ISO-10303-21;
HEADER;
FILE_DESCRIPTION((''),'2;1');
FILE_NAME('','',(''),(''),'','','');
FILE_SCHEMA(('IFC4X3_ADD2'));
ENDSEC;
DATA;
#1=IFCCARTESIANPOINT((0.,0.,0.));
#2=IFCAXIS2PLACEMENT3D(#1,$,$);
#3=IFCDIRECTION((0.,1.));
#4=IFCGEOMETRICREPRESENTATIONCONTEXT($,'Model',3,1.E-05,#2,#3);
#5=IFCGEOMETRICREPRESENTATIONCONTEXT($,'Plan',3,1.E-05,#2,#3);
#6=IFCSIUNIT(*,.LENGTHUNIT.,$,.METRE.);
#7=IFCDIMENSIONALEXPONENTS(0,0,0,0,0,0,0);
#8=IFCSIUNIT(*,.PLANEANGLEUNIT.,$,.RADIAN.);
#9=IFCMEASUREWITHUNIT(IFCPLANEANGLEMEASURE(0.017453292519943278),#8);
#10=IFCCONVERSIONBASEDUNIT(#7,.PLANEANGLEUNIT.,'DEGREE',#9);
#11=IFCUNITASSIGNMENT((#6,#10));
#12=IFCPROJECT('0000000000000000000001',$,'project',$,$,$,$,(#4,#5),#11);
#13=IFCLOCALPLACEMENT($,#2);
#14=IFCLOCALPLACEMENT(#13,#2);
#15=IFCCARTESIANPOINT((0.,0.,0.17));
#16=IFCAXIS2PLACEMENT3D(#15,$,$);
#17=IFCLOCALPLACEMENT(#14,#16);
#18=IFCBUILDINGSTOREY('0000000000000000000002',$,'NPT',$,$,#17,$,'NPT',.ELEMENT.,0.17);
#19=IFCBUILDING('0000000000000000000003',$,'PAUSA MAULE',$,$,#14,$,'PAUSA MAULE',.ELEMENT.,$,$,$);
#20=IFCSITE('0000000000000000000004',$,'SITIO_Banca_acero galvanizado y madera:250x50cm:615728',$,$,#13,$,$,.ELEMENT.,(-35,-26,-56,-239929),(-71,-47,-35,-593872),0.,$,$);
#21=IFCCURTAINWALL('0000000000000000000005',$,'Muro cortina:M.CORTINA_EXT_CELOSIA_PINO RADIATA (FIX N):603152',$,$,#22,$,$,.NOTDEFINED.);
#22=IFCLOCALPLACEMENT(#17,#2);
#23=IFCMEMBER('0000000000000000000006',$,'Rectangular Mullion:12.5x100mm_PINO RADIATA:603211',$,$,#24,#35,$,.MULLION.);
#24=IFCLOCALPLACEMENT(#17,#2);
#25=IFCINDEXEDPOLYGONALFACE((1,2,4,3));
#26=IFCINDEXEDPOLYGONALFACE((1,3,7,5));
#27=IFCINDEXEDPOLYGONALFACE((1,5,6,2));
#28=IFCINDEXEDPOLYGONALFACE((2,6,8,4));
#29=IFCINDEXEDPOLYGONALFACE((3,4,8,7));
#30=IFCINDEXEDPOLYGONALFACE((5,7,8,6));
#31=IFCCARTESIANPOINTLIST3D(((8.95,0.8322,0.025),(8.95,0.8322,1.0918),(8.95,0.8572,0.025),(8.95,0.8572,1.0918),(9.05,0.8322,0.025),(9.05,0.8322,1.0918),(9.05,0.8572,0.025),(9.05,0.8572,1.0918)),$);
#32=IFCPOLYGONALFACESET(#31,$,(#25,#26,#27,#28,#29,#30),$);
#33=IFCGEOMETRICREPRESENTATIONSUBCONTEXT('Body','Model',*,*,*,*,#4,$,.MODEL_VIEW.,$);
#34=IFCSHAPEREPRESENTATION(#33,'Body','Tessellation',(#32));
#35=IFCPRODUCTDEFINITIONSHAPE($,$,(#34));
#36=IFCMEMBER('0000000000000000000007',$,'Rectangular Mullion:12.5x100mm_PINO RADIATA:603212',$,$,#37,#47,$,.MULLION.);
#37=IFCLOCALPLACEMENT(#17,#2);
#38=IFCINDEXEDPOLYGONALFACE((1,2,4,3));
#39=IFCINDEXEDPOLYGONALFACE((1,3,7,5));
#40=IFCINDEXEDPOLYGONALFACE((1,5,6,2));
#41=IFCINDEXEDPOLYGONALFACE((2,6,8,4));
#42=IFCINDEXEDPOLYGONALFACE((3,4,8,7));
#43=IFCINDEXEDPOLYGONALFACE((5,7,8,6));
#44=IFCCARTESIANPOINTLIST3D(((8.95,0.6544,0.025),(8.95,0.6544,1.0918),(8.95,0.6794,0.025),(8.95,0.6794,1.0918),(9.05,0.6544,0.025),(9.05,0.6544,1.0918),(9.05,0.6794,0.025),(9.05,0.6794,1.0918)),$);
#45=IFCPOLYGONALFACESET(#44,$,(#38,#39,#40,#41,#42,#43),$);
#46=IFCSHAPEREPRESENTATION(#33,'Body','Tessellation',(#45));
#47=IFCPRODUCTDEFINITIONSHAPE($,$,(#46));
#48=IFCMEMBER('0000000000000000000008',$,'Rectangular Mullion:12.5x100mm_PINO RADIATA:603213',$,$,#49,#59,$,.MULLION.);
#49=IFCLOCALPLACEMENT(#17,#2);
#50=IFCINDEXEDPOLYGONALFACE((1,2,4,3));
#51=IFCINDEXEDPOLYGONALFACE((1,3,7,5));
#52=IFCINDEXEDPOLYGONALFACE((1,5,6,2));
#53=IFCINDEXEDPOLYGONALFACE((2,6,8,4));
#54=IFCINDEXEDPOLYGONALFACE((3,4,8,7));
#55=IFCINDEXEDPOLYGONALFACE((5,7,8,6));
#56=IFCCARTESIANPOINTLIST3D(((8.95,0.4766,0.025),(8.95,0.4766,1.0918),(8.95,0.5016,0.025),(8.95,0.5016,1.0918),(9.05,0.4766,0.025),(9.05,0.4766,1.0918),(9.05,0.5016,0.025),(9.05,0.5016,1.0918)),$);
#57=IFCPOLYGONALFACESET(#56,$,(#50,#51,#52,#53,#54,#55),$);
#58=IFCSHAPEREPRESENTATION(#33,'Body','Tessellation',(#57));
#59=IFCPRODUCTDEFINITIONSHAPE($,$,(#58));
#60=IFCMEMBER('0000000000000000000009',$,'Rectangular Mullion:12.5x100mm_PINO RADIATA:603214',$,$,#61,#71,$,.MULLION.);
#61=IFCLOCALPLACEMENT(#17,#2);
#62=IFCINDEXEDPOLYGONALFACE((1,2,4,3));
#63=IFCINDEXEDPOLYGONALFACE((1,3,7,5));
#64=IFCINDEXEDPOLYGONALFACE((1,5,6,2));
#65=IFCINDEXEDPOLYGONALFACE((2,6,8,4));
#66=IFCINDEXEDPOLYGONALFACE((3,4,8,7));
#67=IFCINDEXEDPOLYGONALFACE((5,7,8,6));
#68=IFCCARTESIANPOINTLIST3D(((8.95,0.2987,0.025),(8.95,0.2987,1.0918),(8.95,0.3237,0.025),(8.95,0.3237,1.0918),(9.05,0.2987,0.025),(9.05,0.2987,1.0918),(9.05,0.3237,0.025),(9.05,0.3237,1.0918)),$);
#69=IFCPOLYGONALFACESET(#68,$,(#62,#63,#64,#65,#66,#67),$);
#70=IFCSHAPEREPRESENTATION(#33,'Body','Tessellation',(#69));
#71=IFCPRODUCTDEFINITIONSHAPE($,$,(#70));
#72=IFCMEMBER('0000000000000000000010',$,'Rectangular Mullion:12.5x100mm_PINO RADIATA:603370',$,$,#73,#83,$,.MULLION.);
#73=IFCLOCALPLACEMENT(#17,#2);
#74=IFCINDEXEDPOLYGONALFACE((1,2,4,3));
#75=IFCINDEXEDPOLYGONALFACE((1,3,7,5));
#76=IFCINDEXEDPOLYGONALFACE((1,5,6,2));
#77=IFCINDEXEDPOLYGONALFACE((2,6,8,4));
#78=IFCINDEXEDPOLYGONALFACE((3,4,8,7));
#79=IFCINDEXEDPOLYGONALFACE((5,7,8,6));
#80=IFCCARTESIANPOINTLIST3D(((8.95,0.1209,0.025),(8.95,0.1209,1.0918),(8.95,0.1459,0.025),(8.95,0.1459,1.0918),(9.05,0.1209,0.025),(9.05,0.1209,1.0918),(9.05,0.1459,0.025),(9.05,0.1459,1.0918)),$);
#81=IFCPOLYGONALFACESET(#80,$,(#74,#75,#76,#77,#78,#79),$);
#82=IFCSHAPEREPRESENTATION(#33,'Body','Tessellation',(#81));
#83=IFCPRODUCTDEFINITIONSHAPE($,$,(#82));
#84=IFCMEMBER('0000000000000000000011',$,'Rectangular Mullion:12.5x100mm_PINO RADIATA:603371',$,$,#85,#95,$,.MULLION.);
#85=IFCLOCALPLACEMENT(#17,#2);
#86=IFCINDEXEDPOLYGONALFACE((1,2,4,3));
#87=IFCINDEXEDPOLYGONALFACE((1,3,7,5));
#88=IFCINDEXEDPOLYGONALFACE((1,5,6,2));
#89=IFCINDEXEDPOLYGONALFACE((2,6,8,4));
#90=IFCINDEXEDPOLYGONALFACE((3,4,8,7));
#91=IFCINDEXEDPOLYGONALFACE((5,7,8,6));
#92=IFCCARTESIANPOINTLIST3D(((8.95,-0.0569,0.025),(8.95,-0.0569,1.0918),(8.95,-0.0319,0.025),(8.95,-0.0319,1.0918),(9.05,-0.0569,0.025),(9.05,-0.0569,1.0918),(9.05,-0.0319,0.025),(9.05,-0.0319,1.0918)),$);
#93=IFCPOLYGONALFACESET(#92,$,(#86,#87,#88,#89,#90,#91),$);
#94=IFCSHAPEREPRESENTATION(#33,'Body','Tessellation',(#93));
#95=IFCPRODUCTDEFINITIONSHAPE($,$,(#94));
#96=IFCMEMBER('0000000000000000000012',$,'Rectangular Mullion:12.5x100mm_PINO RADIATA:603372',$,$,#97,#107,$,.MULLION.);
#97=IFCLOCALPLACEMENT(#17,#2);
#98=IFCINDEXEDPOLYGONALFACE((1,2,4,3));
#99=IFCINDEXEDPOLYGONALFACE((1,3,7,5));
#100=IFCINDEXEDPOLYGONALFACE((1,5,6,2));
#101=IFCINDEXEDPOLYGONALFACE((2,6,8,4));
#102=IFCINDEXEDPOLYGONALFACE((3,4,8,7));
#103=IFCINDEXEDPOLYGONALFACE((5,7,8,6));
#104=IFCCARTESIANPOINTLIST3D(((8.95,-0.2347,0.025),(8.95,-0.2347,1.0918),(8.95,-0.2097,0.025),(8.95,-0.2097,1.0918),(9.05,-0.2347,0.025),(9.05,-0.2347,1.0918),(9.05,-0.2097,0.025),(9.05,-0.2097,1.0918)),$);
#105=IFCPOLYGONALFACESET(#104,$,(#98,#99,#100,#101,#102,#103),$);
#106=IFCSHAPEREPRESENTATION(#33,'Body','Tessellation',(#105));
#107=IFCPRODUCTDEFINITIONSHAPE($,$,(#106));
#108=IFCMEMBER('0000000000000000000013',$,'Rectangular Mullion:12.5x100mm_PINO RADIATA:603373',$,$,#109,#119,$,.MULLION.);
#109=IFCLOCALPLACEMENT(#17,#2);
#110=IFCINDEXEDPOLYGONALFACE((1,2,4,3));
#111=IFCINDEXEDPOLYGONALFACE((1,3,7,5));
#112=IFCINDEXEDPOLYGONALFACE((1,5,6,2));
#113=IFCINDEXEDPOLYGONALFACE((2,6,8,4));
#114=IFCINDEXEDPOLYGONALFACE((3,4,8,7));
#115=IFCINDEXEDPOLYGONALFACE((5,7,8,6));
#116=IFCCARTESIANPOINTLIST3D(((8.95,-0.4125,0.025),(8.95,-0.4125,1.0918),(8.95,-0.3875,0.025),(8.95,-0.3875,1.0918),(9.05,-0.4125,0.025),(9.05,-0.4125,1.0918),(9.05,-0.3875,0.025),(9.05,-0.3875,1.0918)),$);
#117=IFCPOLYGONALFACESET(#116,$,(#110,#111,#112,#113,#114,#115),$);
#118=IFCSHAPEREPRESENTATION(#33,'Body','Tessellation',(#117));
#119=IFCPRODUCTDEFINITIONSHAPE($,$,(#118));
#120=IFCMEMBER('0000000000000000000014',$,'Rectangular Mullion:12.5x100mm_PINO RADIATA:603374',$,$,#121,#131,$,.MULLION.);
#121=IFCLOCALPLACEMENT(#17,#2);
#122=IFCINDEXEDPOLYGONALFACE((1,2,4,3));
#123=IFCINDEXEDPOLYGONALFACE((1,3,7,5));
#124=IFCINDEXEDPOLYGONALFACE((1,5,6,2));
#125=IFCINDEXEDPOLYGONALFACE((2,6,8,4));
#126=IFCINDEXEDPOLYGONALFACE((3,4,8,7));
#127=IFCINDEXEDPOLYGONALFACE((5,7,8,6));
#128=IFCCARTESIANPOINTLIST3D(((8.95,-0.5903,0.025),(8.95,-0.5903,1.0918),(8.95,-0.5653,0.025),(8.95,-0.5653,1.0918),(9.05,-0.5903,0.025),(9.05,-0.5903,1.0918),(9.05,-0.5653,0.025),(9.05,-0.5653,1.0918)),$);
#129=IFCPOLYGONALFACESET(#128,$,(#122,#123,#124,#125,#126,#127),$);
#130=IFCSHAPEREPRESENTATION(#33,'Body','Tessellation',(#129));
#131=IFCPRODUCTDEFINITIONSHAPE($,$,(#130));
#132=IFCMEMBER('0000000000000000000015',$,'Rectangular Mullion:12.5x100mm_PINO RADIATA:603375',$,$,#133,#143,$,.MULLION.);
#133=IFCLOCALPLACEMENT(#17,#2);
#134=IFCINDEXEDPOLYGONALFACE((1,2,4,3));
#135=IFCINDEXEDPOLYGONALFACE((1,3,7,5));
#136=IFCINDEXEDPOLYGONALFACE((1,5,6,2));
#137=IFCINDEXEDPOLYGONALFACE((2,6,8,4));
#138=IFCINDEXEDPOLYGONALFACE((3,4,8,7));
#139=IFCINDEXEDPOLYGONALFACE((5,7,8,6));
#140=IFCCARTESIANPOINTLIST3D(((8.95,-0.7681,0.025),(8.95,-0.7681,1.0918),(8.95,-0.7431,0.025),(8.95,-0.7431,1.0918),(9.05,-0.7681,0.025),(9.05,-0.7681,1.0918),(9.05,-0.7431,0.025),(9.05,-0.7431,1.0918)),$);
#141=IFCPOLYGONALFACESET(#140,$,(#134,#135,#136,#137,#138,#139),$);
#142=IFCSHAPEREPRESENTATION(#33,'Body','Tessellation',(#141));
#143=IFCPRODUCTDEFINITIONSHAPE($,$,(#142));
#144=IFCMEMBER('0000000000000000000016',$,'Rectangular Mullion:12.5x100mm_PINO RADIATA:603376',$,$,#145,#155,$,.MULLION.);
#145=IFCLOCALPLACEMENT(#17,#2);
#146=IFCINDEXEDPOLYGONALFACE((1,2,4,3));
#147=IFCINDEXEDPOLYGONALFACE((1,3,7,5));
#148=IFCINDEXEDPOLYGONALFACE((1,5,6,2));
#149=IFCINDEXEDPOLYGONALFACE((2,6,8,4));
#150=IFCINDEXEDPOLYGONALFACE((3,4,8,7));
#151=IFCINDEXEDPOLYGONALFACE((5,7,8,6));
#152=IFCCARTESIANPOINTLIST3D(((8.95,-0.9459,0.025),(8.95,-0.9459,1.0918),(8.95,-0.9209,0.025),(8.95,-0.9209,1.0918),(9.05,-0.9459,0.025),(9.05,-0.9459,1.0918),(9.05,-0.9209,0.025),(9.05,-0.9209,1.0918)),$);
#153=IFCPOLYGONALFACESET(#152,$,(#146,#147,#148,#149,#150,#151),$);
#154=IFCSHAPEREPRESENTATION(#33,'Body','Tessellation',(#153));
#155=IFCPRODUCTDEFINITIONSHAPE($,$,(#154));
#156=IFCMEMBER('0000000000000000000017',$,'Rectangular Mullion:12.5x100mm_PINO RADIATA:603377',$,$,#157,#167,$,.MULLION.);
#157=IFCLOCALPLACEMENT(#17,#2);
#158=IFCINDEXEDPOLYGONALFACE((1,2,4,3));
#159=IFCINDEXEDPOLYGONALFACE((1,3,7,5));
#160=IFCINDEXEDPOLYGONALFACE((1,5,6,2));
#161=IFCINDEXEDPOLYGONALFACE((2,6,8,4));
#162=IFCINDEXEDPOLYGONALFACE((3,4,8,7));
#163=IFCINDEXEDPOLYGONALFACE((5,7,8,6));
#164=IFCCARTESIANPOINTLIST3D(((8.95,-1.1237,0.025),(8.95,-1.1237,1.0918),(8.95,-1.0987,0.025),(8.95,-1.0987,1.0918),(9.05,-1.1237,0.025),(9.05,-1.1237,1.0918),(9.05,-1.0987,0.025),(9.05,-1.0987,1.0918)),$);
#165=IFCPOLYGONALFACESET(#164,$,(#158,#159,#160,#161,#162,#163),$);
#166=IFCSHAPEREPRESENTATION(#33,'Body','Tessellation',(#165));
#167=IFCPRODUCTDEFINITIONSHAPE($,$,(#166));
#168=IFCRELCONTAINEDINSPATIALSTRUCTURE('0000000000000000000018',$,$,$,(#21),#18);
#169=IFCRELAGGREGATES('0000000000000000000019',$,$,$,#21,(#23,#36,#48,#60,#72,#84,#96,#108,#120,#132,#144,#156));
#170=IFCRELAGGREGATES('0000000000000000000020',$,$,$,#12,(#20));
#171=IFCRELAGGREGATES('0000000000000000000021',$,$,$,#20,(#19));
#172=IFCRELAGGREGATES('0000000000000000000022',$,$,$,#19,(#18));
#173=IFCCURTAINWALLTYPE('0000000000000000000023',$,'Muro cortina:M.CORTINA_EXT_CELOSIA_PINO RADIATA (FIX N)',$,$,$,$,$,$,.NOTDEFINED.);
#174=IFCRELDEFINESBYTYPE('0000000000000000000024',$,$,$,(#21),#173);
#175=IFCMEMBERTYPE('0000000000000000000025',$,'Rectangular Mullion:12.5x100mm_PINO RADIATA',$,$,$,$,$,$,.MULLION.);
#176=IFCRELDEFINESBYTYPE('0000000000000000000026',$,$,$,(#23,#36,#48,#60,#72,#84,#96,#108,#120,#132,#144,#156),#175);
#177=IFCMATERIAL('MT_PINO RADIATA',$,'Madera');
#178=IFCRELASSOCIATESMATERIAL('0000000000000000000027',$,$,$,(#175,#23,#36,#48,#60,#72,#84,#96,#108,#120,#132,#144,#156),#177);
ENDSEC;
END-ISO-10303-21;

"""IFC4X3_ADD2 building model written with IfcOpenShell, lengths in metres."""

from ifc_helpers import new_model, entity, si_unit, converted_unit, direction, frame, frame_2d, origin, origin_2d_with_axis, place, context, subcontext, project, spatial, rectangle, extrude, source, transform, mapped, material, material_profile, profile_set, profile_usage, type_object, type_shapes, element, aggregate, save


model = new_model("IFC4X3_ADD2")

# Units and contexts
model_context = context("Model", 3, precision=1e-05, world=origin(), true_north=direction((0.0, 1.0)))
plan_context = context("Plan", 3, precision=1e-05, world=origin(), true_north=direction((0.0, 1.0)))
body_context = subcontext(model_context, "Body", "Model", "MODEL_VIEW")
ifc_project = project(units=[si_unit("LENGTHUNIT", "METRE"), converted_unit("PLANEANGLEUNIT", "DEGREE", entity("IfcPlaneAngleMeasure", 0.017453292519943278), si_unit("PLANEANGLEUNIT", "RADIAN"), dimensions=[0, 0, 0, 0, 0, 0, 0])], contexts=[model_context, plan_context])

# Site, building, storey
site_placement = place(None, origin())
site = spatial("IfcSite", under=ifc_project, at=site_placement, Name="SITIO_Banca_acero galvanizado y madera:250x50cm:615728", CompositionType="ELEMENT", RefLatitude=(-35, -26, -56, -239929), RefLongitude=(-71, -47, -35, -593872), RefElevation=0.0)
building_placement = place(site_placement, origin())
building = spatial("IfcBuilding", under=site, at=building_placement, Name="PAUSA MAULE", LongName="PAUSA MAULE", CompositionType="ELEMENT")
storey_placement = place(building_placement, frame((0.0, 0.0, 0.17)))
storey = spatial("IfcBuildingStorey", under=building, at=storey_placement, Name="NPT", LongName="NPT", CompositionType="ELEMENT", Elevation=0.17)

# Curtain wall, members
curtain_wall_type = type_object("IfcCurtainWallType", Name="Muro cortina:M.CORTINA_EXT_CELOSIA_PINO RADIATA (FIX N)", PredefinedType="NOTDEFINED")
curtain_wall_placement = place(storey_placement, frame((0.0, 0.0, -0.17)))
curtain_wall = element("IfcCurtainWall", 1, at=curtain_wall_placement, inside=storey, type_object=curtain_wall_type, Name="Muro cortina:M.CORTINA_EXT_CELOSIA_PINO RADIATA (FIX N):603152", PredefinedType="NOTDEFINED")
ifc_material = material(Name="MT_PINO RADIATA", Category="Madera")
ifc_material_profile = material_profile(ifc_material, rectangle(XDim=0.025, YDim=0.1, at=frame_2d((0.0, 0.0), x_axis=(1.0, 0.0))), Name="12.5x100mm_PINO RADIATA")
ifc_profile_set = profile_set([ifc_material_profile], Name="12.5x100mm_PINO RADIATA")
ifc_profile_usage = profile_usage(ifc_profile_set)
member_type_1 = type_object("IfcMemberType", Name="Rectangular Mullion:12.5x100mm_PINO RADIATA", PredefinedType="MULLION", material=ifc_profile_set)
shared_shape_1 = source(origin(), body_context, "Body", "SweptSolid", [
    extrude(rectangle(XDim=0.025, YDim=0.1, at=origin_2d_with_axis()), frame((0.0, 0.0, -1.0668), z_axis=(0.0, 0.0, 1.0), x_axis=(-1.0, 0.0, 0.0)), (0.0, 0.0, 1.0), 1.0668),
])
type_shapes(member_type_1, [shared_shape_1])
member_1_placement = place(curtain_wall_placement, frame((9.0, 0.8447, 0.195), z_axis=(0.0, 0.0, -1.0), x_axis=(0.0, -1.0, 0.0)))
member_1 = element("IfcMember", 2, at=member_1_placement, type_object=member_type_1, material=ifc_profile_usage, Name="Rectangular Mullion:12.5x100mm_PINO RADIATA:603211", PredefinedType="MULLION", context=body_context, shape_type="MappedRepresentation", body=[
    mapped(shared_shape_1, transform((0.0, 0.0, 0.0), scale=1.0)),
])
member_2_placement = place(curtain_wall_placement, frame((9.0, 0.6669, 0.195), z_axis=(0.0, 0.0, -1.0), x_axis=(0.0, -1.0, 0.0)))
member_2 = element("IfcMember", 3, at=member_2_placement, type_object=member_type_1, material=ifc_profile_usage, Name="Rectangular Mullion:12.5x100mm_PINO RADIATA:603212", PredefinedType="MULLION", context=body_context, shape_type="MappedRepresentation", body=[
    mapped(shared_shape_1, transform((0.0, 0.0, 0.0), scale=1.0)),
])
member_3_placement = place(curtain_wall_placement, frame((9.0, 0.4891, 0.195), z_axis=(0.0, 0.0, -1.0), x_axis=(0.0, -1.0, 0.0)))
member_3 = element("IfcMember", 4, at=member_3_placement, type_object=member_type_1, material=ifc_profile_usage, Name="Rectangular Mullion:12.5x100mm_PINO RADIATA:603213", PredefinedType="MULLION", context=body_context, shape_type="MappedRepresentation", body=[
    mapped(shared_shape_1, transform((0.0, 0.0, 0.0), scale=1.0)),
])
member_4_placement = place(curtain_wall_placement, frame((9.0, 0.3112, 0.195), z_axis=(0.0, 0.0, -1.0), x_axis=(0.0, -1.0, 0.0)))
member_4 = element("IfcMember", 5, at=member_4_placement, type_object=member_type_1, material=ifc_profile_usage, Name="Rectangular Mullion:12.5x100mm_PINO RADIATA:603214", PredefinedType="MULLION", context=body_context, shape_type="MappedRepresentation", body=[
    mapped(shared_shape_1, transform((0.0, 0.0, 0.0), scale=1.0)),
])
member_5_placement = place(curtain_wall_placement, frame((9.0, 0.1334, 0.195), z_axis=(0.0, 0.0, -1.0), x_axis=(0.0, -1.0, 0.0)))
member_5 = element("IfcMember", 6, at=member_5_placement, type_object=member_type_1, material=ifc_profile_usage, Name="Rectangular Mullion:12.5x100mm_PINO RADIATA:603370", PredefinedType="MULLION", context=body_context, shape_type="MappedRepresentation", body=[
    mapped(shared_shape_1, transform((0.0, 0.0, 0.0), scale=1.0)),
])
member_6_placement = place(curtain_wall_placement, frame((9.0, -0.0444, 0.195), z_axis=(0.0, 0.0, -1.0), x_axis=(0.0, -1.0, 0.0)))
member_6 = element("IfcMember", 7, at=member_6_placement, type_object=member_type_1, material=ifc_profile_usage, Name="Rectangular Mullion:12.5x100mm_PINO RADIATA:603371", PredefinedType="MULLION", context=body_context, shape_type="MappedRepresentation", body=[
    mapped(shared_shape_1, transform((0.0, 0.0, 0.0), scale=1.0)),
])
member_7_placement = place(curtain_wall_placement, frame((9.0, -0.2222, 0.195), z_axis=(0.0, 0.0, -1.0), x_axis=(0.0, -1.0, 0.0)))
member_7 = element("IfcMember", 8, at=member_7_placement, type_object=member_type_1, material=ifc_profile_usage, Name="Rectangular Mullion:12.5x100mm_PINO RADIATA:603372", PredefinedType="MULLION", context=body_context, shape_type="MappedRepresentation", body=[
    mapped(shared_shape_1, transform((0.0, 0.0, 0.0), scale=1.0)),
])
member_8_placement = place(curtain_wall_placement, frame((9.0, -0.4, 0.195), z_axis=(0.0, 0.0, -1.0), x_axis=(0.0, -1.0, 0.0)))
member_8 = element("IfcMember", 9, at=member_8_placement, type_object=member_type_1, material=ifc_profile_usage, Name="Rectangular Mullion:12.5x100mm_PINO RADIATA:603373", PredefinedType="MULLION", context=body_context, shape_type="MappedRepresentation", body=[
    mapped(shared_shape_1, transform((0.0, 0.0, 0.0), scale=1.0)),
])
member_9_placement = place(curtain_wall_placement, frame((9.0, -0.5778, 0.195), z_axis=(0.0, 0.0, -1.0), x_axis=(0.0, -1.0, 0.0)))
member_9 = element("IfcMember", 10, at=member_9_placement, type_object=member_type_1, material=ifc_profile_usage, Name="Rectangular Mullion:12.5x100mm_PINO RADIATA:603374", PredefinedType="MULLION", context=body_context, shape_type="MappedRepresentation", body=[
    mapped(shared_shape_1, transform((0.0, 0.0, 0.0), scale=1.0)),
])
member_10_placement = place(curtain_wall_placement, frame((9.0, -0.7556, 0.195), z_axis=(0.0, 0.0, -1.0), x_axis=(0.0, -1.0, 0.0)))
member_10 = element("IfcMember", 11, at=member_10_placement, type_object=member_type_1, material=ifc_profile_usage, Name="Rectangular Mullion:12.5x100mm_PINO RADIATA:603375", PredefinedType="MULLION", context=body_context, shape_type="MappedRepresentation", body=[
    mapped(shared_shape_1, transform((0.0, 0.0, 0.0), scale=1.0)),
])
member_11_placement = place(curtain_wall_placement, frame((9.0, -0.9334, 0.195), z_axis=(0.0, 0.0, -1.0), x_axis=(0.0, -1.0, 0.0)))
member_11 = element("IfcMember", 12, at=member_11_placement, type_object=member_type_1, material=ifc_profile_usage, Name="Rectangular Mullion:12.5x100mm_PINO RADIATA:603376", PredefinedType="MULLION", context=body_context, shape_type="MappedRepresentation", body=[
    mapped(shared_shape_1, transform((0.0, 0.0, 0.0), scale=1.0)),
])
member_12_placement = place(curtain_wall_placement, frame((9.0, -1.1112, 0.195), z_axis=(0.0, 0.0, -1.0), x_axis=(0.0, -1.0, 0.0)))
member_12 = element("IfcMember", 13, at=member_12_placement, type_object=member_type_1, material=ifc_profile_usage, Name="Rectangular Mullion:12.5x100mm_PINO RADIATA:603377", PredefinedType="MULLION", context=body_context, shape_type="MappedRepresentation", body=[
    mapped(shared_shape_1, transform((0.0, 0.0, 0.0), scale=1.0)),
])
aggregate(curtain_wall, [member_1, member_2, member_3, member_4, member_5, member_6, member_7, member_8, member_9, member_10, member_11, member_12])

save(model, "model.ifc")
